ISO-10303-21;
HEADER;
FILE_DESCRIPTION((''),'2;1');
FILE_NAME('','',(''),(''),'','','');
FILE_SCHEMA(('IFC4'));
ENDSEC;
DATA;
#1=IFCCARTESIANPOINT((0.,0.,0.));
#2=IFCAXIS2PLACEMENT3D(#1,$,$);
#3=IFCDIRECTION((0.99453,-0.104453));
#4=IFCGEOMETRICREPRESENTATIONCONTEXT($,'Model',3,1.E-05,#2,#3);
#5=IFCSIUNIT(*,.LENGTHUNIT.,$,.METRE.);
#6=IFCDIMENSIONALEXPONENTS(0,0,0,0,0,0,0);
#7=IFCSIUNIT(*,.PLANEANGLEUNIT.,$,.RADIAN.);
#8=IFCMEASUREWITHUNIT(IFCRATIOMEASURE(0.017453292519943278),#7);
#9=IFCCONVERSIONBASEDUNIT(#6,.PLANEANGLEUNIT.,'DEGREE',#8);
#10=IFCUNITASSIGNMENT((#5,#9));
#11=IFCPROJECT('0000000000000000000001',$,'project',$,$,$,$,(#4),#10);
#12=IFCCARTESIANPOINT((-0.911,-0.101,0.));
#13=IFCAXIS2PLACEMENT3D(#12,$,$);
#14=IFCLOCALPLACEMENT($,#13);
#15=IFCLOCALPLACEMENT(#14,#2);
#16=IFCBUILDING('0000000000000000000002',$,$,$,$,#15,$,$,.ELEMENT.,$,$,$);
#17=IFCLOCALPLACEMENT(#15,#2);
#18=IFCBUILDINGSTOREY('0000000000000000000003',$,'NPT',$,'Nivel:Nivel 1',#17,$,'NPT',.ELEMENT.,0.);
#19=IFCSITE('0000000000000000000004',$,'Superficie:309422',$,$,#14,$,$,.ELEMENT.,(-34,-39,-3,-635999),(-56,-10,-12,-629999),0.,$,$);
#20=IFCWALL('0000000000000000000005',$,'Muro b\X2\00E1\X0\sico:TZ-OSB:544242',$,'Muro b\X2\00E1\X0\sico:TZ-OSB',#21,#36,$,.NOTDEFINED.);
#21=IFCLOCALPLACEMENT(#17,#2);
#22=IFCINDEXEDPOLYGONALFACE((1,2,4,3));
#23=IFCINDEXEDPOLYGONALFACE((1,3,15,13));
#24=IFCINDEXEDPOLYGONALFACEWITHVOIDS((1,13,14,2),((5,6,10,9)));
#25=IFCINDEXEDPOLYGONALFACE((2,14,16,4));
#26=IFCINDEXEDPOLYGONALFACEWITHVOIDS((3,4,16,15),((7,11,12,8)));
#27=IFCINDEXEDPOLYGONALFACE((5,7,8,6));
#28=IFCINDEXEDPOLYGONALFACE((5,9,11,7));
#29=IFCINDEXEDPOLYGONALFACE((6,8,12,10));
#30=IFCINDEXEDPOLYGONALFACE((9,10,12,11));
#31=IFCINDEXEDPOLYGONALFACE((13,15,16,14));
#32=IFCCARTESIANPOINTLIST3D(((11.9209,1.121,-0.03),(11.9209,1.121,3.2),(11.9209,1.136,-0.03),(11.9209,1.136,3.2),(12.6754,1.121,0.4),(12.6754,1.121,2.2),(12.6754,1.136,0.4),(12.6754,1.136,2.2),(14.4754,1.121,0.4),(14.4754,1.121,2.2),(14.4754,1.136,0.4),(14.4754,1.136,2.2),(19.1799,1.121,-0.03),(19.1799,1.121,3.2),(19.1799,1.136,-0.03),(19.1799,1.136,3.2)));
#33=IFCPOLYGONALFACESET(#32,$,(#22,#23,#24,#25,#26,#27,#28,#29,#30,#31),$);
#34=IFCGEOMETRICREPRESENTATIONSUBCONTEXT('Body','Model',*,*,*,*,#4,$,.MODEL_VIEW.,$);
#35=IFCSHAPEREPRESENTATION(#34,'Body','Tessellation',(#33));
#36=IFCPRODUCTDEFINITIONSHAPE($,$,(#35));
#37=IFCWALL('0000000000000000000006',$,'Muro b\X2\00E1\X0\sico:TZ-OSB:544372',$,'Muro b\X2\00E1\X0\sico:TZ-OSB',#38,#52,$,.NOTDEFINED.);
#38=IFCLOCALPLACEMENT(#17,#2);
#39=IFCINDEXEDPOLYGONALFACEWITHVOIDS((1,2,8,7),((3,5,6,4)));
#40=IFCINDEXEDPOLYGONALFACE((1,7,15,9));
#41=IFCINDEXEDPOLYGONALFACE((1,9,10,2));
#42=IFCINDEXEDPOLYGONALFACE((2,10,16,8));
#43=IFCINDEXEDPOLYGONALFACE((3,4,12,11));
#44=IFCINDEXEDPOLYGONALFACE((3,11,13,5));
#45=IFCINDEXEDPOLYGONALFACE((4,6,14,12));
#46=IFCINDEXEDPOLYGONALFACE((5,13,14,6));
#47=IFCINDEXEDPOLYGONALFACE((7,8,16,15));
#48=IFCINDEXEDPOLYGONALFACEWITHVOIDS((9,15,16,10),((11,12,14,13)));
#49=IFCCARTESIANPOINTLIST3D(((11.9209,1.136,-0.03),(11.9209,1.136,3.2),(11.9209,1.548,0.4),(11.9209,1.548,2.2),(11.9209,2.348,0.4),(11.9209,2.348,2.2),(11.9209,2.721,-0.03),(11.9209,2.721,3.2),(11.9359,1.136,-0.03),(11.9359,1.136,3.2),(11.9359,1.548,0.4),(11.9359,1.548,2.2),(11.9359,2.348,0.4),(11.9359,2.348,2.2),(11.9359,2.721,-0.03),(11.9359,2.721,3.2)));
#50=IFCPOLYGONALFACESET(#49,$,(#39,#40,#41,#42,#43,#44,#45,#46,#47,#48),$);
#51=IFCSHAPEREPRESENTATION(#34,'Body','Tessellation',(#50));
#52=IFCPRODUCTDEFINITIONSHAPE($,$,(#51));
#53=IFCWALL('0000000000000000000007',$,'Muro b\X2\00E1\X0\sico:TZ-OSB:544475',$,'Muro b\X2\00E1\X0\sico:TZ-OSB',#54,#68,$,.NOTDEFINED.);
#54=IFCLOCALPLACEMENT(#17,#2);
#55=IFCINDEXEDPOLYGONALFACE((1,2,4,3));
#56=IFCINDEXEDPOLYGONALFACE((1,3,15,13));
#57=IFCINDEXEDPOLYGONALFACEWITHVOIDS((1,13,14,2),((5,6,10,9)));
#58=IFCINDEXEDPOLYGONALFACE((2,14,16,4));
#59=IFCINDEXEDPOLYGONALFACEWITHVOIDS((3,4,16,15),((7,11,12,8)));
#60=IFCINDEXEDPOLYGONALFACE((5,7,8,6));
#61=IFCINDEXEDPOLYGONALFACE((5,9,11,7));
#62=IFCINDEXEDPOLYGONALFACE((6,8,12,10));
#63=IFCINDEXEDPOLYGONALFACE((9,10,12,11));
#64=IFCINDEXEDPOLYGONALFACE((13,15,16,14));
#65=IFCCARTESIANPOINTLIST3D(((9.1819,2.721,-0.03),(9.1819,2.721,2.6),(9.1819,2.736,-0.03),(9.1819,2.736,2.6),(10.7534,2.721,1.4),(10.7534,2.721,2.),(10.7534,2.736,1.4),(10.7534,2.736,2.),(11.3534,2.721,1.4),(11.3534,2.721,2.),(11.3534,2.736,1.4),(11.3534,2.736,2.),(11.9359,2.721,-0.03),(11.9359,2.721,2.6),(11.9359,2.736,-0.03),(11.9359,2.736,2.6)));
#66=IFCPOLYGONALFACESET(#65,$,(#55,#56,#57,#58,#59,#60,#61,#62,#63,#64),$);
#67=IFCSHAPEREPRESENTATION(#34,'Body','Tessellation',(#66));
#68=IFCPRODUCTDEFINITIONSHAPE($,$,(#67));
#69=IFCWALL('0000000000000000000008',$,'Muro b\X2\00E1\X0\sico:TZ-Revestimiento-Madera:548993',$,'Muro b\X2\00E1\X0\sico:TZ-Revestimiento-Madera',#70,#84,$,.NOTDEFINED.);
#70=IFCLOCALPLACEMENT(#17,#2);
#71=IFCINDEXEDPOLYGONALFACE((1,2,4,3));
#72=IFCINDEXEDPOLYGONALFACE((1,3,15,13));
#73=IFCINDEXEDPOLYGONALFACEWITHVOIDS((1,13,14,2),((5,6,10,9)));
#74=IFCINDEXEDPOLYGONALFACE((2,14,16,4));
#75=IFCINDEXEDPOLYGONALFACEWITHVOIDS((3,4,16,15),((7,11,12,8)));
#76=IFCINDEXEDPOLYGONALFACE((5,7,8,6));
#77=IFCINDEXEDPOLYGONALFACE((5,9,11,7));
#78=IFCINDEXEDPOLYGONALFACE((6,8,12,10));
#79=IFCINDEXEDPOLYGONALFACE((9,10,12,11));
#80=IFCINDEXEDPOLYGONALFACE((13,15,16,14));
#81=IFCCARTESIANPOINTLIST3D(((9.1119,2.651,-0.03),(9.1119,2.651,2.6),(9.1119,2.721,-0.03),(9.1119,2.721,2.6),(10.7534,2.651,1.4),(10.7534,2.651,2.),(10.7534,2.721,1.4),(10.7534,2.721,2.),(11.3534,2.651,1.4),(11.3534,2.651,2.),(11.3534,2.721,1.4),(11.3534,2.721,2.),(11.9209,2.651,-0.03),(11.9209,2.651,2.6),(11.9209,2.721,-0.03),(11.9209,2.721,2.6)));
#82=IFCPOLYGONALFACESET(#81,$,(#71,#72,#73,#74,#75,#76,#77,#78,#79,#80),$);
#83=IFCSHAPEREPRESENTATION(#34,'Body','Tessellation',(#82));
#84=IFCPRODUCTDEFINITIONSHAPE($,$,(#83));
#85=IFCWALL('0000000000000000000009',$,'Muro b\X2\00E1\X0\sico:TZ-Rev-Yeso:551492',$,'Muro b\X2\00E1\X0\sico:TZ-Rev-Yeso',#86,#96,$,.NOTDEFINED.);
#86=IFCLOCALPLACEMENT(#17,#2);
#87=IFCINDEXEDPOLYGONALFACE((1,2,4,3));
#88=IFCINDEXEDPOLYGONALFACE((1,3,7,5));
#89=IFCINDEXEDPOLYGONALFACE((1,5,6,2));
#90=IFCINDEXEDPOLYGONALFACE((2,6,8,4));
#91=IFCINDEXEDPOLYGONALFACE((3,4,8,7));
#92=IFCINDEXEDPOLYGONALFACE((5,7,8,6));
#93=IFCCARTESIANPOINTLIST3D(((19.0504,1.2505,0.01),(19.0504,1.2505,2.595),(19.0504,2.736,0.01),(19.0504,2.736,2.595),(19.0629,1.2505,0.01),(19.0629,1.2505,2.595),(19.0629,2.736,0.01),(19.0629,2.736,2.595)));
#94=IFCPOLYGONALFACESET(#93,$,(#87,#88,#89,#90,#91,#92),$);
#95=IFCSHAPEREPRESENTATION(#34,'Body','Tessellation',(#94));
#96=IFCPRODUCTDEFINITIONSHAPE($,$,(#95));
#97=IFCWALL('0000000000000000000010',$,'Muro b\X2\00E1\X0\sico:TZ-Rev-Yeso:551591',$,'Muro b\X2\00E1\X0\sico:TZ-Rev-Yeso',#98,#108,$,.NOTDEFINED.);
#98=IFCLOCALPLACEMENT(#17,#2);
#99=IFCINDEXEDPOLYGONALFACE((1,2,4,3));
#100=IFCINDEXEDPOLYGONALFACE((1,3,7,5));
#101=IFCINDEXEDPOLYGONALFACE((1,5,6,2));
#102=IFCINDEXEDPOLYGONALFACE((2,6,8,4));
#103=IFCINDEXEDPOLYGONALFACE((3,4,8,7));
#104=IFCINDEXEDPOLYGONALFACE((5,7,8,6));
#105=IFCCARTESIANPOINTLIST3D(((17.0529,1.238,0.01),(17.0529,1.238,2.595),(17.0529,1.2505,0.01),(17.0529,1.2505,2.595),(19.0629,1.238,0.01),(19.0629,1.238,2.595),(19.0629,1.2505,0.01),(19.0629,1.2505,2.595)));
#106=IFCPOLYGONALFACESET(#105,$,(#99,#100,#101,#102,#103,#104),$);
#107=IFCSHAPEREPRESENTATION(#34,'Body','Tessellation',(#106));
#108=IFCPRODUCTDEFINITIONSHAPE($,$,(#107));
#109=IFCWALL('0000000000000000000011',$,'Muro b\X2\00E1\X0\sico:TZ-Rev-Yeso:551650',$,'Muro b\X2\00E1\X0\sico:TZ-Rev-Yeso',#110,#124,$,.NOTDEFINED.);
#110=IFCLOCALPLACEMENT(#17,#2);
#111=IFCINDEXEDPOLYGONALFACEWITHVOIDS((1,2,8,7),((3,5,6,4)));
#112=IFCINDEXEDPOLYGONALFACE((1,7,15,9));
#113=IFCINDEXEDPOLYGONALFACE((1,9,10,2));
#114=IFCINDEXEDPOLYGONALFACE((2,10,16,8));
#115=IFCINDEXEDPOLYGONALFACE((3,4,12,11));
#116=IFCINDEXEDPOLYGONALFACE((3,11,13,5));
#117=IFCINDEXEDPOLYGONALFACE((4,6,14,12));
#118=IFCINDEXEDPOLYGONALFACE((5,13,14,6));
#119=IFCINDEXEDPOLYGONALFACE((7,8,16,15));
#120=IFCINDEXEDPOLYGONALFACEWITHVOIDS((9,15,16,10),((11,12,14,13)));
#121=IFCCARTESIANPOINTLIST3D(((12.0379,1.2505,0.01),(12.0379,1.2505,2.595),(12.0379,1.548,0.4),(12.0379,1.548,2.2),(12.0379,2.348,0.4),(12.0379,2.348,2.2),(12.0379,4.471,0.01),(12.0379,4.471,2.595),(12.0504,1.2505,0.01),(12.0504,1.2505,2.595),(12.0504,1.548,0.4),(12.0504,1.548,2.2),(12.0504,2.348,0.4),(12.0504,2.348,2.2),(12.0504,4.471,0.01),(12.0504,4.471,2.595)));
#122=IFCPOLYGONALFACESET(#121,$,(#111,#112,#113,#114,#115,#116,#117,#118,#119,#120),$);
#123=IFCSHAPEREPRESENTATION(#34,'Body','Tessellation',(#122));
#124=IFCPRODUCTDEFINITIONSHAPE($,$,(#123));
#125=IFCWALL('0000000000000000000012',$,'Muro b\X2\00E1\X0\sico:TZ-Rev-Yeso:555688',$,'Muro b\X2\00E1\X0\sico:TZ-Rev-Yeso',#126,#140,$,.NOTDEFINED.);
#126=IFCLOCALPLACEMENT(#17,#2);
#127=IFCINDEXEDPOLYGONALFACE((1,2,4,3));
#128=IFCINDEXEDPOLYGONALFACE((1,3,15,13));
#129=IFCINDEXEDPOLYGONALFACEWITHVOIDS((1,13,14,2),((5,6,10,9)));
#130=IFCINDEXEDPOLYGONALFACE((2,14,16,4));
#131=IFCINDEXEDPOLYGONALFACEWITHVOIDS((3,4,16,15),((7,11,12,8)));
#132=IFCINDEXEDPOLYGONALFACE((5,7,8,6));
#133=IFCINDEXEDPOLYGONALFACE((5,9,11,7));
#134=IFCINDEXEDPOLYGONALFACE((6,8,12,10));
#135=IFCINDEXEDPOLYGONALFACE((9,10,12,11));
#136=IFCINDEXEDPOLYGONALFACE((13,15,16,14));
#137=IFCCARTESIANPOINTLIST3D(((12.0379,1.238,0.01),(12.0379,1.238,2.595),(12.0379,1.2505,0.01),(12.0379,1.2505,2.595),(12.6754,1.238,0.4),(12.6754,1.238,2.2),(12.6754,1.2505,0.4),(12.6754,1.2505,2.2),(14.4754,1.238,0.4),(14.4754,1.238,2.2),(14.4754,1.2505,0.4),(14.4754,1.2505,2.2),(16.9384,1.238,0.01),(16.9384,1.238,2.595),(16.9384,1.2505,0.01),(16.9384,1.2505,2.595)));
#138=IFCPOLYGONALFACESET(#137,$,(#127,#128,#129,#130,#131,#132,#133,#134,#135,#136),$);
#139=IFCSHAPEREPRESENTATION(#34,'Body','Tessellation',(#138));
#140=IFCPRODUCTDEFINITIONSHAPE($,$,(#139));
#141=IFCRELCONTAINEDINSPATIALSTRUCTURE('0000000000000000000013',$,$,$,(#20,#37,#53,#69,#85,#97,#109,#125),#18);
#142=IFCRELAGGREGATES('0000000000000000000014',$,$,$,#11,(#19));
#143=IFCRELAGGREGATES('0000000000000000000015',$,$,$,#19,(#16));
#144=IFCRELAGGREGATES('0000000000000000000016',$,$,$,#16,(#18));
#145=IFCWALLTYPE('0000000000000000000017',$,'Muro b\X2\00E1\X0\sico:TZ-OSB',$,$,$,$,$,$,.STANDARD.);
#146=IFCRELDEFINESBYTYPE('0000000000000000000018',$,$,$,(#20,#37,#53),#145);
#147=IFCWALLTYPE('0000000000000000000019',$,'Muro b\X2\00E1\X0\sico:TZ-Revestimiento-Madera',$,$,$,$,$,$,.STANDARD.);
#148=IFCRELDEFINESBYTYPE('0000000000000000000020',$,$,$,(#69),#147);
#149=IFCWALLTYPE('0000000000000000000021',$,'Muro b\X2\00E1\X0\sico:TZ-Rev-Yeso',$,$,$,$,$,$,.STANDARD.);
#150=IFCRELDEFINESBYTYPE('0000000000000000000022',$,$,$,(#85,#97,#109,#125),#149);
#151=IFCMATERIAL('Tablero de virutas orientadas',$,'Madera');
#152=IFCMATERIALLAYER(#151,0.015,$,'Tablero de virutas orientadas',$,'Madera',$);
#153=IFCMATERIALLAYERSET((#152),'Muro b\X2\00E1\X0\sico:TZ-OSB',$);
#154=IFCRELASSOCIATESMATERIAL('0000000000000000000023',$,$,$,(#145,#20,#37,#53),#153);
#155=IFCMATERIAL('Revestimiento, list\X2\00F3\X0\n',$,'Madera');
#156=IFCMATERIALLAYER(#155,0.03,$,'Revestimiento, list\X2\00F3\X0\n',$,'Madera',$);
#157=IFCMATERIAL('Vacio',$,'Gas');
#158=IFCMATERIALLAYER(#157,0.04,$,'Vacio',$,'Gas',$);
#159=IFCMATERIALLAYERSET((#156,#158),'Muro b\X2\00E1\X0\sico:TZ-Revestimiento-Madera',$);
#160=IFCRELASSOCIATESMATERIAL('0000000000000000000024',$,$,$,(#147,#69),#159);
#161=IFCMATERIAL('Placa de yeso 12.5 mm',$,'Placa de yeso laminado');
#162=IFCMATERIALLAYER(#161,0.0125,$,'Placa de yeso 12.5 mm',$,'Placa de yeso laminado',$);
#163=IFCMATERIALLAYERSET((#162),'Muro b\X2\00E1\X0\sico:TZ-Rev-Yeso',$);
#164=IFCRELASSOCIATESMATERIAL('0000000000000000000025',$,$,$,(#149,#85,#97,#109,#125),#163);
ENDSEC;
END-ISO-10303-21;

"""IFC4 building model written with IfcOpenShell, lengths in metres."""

from ifc_helpers import new_model, entity, si_unit, converted_unit, direction, frame, frame_2d, origin, place, context, subcontext, project, spatial, rectangle, extrude, material, layer, layer_set, layer_usage, type_object, element, save


model = new_model("IFC4")

# Units and contexts
model_context = context("Model", 3, precision=1e-05, world=origin(), true_north=direction((0.99453, -0.104453)))
body_context = subcontext(model_context, "Body", "Model", "MODEL_VIEW")
ifc_project = project(units=[si_unit("LENGTHUNIT", "METRE"), converted_unit("PLANEANGLEUNIT", "DEGREE", entity("IfcRatioMeasure", 0.017453292519943278), si_unit("PLANEANGLEUNIT", "RADIAN"), dimensions=[0, 0, 0, 0, 0, 0, 0])], contexts=[model_context])

# Site, building, storey
site_placement = place(None, frame((-0.911, -0.101, 0.0)))
site = spatial("IfcSite", under=ifc_project, at=site_placement, Name="Superficie:309422", CompositionType="ELEMENT", RefLatitude=(-34, -39, -3, -635999), RefLongitude=(-56, -10, -12, -629999), RefElevation=0.0)
building_placement = place(site_placement, origin())
building = spatial("IfcBuilding", under=site, at=building_placement, CompositionType="ELEMENT")
storey_placement = place(building_placement, origin())
storey = spatial("IfcBuildingStorey", under=building, at=storey_placement, Name="NPT", ObjectType="Nivel:Nivel 1", LongName="NPT", CompositionType="ELEMENT", Elevation=0.0)

# Walls, openings
ifc_material_1 = material(Name="Tablero de virutas orientadas", Category="Madera")
ifc_layer_1 = layer(ifc_material_1, 0.015, Name="Tablero de virutas orientadas", Category="Madera")
ifc_layer_set_1 = layer_set([ifc_layer_1], Name="Muro básico:TZ-OSB")
ifc_layer_usage_1 = layer_usage(ifc_layer_set_1, "AXIS2", "NEGATIVE", 0.0075)
wall_type_1 = type_object("IfcWallType", Name="Muro básico:TZ-OSB", PredefinedType="STANDARD", material=ifc_layer_set_1)
wall_1_placement = place(storey_placement, frame((19.1799, 1.1285, -0.03), z_axis=(0.0, 0.0, 1.0), x_axis=(-1.0, 0.0, 0.0)))
wall_1 = element("IfcWall", 1, at=wall_1_placement, inside=storey, type_object=wall_type_1, material=ifc_layer_usage_1, Name="Muro básico:TZ-OSB:544242", ObjectType="Muro básico:TZ-OSB", PredefinedType="NOTDEFINED", context=body_context, shape_type="SweptSolid", body=[
    extrude(rectangle(XDim=7.259, YDim=0.015, at=frame_2d((3.6295, 0.0), x_axis=(-1.0, 0.0))), origin(), (0.0, 0.0, 1.0), 3.23),
])
opening_1_placement = place(wall_1_placement, frame((6.5045, 1.4145, 0.43)))
element("IfcOpeningElement", 2, at=opening_1_placement, cuts=wall_1, PredefinedType="OPENING", context=body_context, shape_type="SweptSolid", body=[
    extrude(rectangle(XDim=1.8, YDim=1.8, at=frame_2d((0.0, 0.0), x_axis=(0.0, 1.0))), frame((-0.9, -3.048, 0.9), z_axis=(0.0, 1.0, 0.0), x_axis=(-1.0, 0.0, 0.0)), (0.0, 0.0, 1.0), 3.048),
])
ifc_layer_usage_2 = layer_usage(ifc_layer_set_1, "AXIS2", "NEGATIVE", 0.0075)
wall_2_placement = place(storey_placement, frame((11.9284, 1.136, -0.03), z_axis=(0.0, 0.0, 1.0), x_axis=(0.0, 1.0, 0.0)))
wall_2 = element("IfcWall", 3, at=wall_2_placement, inside=storey, type_object=wall_type_1, material=ifc_layer_usage_2, Name="Muro básico:TZ-OSB:544372", ObjectType="Muro básico:TZ-OSB", PredefinedType="NOTDEFINED", context=body_context, shape_type="SweptSolid", body=[
    extrude(rectangle(XDim=1.585, YDim=0.015, at=frame_2d((0.7925, 0.0), x_axis=(-1.0, 0.0))), origin(), (0.0, 0.0, 1.0), 3.23),
])
opening_2_placement = place(wall_2_placement, frame((0.412, 1.4145, 0.43)))
element("IfcOpeningElement", 4, at=opening_2_placement, cuts=wall_2, PredefinedType="OPENING", context=body_context, shape_type="SweptSolid", body=[
    extrude(rectangle(XDim=1.8, YDim=0.8, at=frame_2d((0.0, 0.0), x_axis=(0.0, 1.0))), frame((0.4, -3.048, 0.9), z_axis=(0.0, 1.0, 0.0), x_axis=(-1.0, 0.0, 0.0)), (0.0, 0.0, 1.0), 3.048),
])
ifc_layer_usage_3 = layer_usage(ifc_layer_set_1, "AXIS2", "NEGATIVE", 0.0075)
wall_3_placement = place(storey_placement, frame((11.9359, 2.7285, -0.03), z_axis=(0.0, 0.0, 1.0), x_axis=(-1.0, 0.0, 0.0)))
wall_3 = element("IfcWall", 5, at=wall_3_placement, inside=storey, type_object=wall_type_1, material=ifc_layer_usage_3, Name="Muro básico:TZ-OSB:544475", ObjectType="Muro básico:TZ-OSB", PredefinedType="NOTDEFINED", context=body_context, shape_type="SweptSolid", body=[
    extrude(rectangle(XDim=2.754, YDim=0.015, at=frame_2d((1.377, 0.0), x_axis=(-1.0, 0.0))), origin(), (0.0, 0.0, 1.0), 2.63),
])
opening_3_placement = place(wall_3_placement, frame((1.1825, 1.4145, 1.43)))
element("IfcOpeningElement", 6, at=opening_3_placement, cuts=wall_3, PredefinedType="OPENING", context=body_context, shape_type="SweptSolid", body=[
    extrude(rectangle(XDim=0.6, YDim=0.6, at=frame_2d((0.0, 0.0), x_axis=(0.0, 1.0))), frame((-0.3, -3.048, 0.3), z_axis=(0.0, 1.0, 0.0), x_axis=(-1.0, 0.0, 0.0)), (0.0, 0.0, 1.0), 3.048),
])
ifc_material_2 = material(Name="Revestimiento, listón", Category="Madera")
ifc_layer_2 = layer(ifc_material_2, 0.03, Name="Revestimiento, listón", Category="Madera")
ifc_material_3 = material(Name="Vacio", Category="Gas")
ifc_layer_3 = layer(ifc_material_3, 0.04, Name="Vacio", Category="Gas")
ifc_layer_set_2 = layer_set([ifc_layer_2, ifc_layer_3], Name="Muro básico:TZ-Revestimiento-Madera")
ifc_layer_usage_4 = layer_usage(ifc_layer_set_2, "AXIS2", "NEGATIVE", 0.035)
wall_type_2 = type_object("IfcWallType", Name="Muro básico:TZ-Revestimiento-Madera", PredefinedType="STANDARD", material=ifc_layer_set_2)
wall_4_placement = place(storey_placement, frame((11.9209, 2.686, -0.03), z_axis=(0.0, 0.0, 1.0), x_axis=(-1.0, 0.0, 0.0)))
wall_4 = element("IfcWall", 7, at=wall_4_placement, inside=storey, type_object=wall_type_2, material=ifc_layer_usage_4, Name="Muro básico:TZ-Revestimiento-Madera:548993", ObjectType="Muro básico:TZ-Revestimiento-Madera", PredefinedType="NOTDEFINED", context=body_context, shape_type="SweptSolid", body=[
    extrude(rectangle(XDim=2.809, YDim=0.07, at=frame_2d((1.4045, 0.0), x_axis=(1.0, 0.0))), origin(), (0.0, 0.0, 1.0), 2.63),
])
opening_4_placement = place(wall_4_placement, frame((1.1675, 1.372, 1.43)))
element("IfcOpeningElement", 8, at=opening_4_placement, cuts=wall_4, PredefinedType="OPENING", context=body_context, shape_type="SweptSolid", body=[
    extrude(rectangle(XDim=0.6, YDim=0.6, at=frame_2d((0.0, 0.0), x_axis=(0.0, 1.0))), frame((-0.3, -3.048, 0.3), z_axis=(0.0, 1.0, 0.0), x_axis=(-1.0, 0.0, 0.0)), (0.0, 0.0, 1.0), 3.048),
])

# Walls
ifc_material_4 = material(Name="Placa de yeso 12.5 mm", Category="Placa de yeso laminado")
ifc_layer_4 = layer(ifc_material_4, 0.0125, Name="Placa de yeso 12.5 mm", Category="Placa de yeso laminado")
ifc_layer_set_3 = layer_set([ifc_layer_4], Name="Muro básico:TZ-Rev-Yeso")
ifc_layer_usage_5 = layer_usage(ifc_layer_set_3, "AXIS2", "NEGATIVE", 0.0063)
wall_type_3 = type_object("IfcWallType", Name="Muro básico:TZ-Rev-Yeso", PredefinedType="STANDARD", material=ifc_layer_set_3)
wall_5_placement = place(storey_placement, frame((19.0567, 2.736, 0.01), z_axis=(0.0, 0.0, 1.0), x_axis=(0.0, -1.0, 0.0)))
element("IfcWall", 9, at=wall_5_placement, inside=storey, type_object=wall_type_3, material=ifc_layer_usage_5, Name="Muro básico:TZ-Rev-Yeso:551492", ObjectType="Muro básico:TZ-Rev-Yeso", PredefinedType="NOTDEFINED", context=body_context, shape_type="SweptSolid", body=[
    extrude(rectangle(XDim=1.4855, YDim=0.0125, at=frame_2d((0.7428, 0.0), x_axis=(-1.0, 0.0))), origin(), (0.0, 0.0, 1.0), 2.585),
])
ifc_layer_usage_6 = layer_usage(ifc_layer_set_3, "AXIS2", "NEGATIVE", 0.0063)
wall_6_placement = place(storey_placement, frame((19.0629, 1.2443, 0.01), z_axis=(0.0, 0.0, 1.0), x_axis=(-1.0, 0.0, 0.0)))
element("IfcWall", 10, at=wall_6_placement, inside=storey, type_object=wall_type_3, material=ifc_layer_usage_6, Name="Muro básico:TZ-Rev-Yeso:551591", ObjectType="Muro básico:TZ-Rev-Yeso", PredefinedType="NOTDEFINED", context=body_context, shape_type="SweptSolid", body=[
    extrude(rectangle(XDim=2.01, YDim=0.0125, at=frame_2d((1.005, 0.0), x_axis=(-1.0, 0.0))), origin(), (0.0, 0.0, 1.0), 2.585),
])

# Walls, openings
ifc_layer_usage_7 = layer_usage(ifc_layer_set_3, "AXIS2", "NEGATIVE", 0.0063)
wall_7_placement = place(storey_placement, frame((12.0442, 1.2505, 0.01), z_axis=(0.0, 0.0, 1.0), x_axis=(0.0, 1.0, 0.0)))
wall_7 = element("IfcWall", 11, at=wall_7_placement, inside=storey, type_object=wall_type_3, material=ifc_layer_usage_7, Name="Muro básico:TZ-Rev-Yeso:551650", ObjectType="Muro básico:TZ-Rev-Yeso", PredefinedType="NOTDEFINED", context=body_context, shape_type="SweptSolid", body=[
    extrude(rectangle(XDim=3.2205, YDim=0.0125, at=frame_2d((1.6102, 0.0), x_axis=(-1.0, 0.0))), origin(), (0.0, 0.0, 1.0), 2.585),
])
opening_5_placement = place(wall_7_placement, frame((0.2975, 1.5303, 0.39)))
element("IfcOpeningElement", 12, at=opening_5_placement, cuts=wall_7, PredefinedType="OPENING", context=body_context, shape_type="SweptSolid", body=[
    extrude(rectangle(XDim=1.8, YDim=0.8, at=frame_2d((0.0, 0.0), x_axis=(0.0, 1.0))), frame((0.4, -3.048, 0.9), z_axis=(0.0, 1.0, 0.0), x_axis=(-1.0, 0.0, 0.0)), (0.0, 0.0, 1.0), 3.048),
])
ifc_layer_usage_8 = layer_usage(ifc_layer_set_3, "AXIS2", "NEGATIVE", 0.0063)
wall_8_placement = place(storey_placement, frame((16.9384, 1.2443, 0.01), z_axis=(0.0, 0.0, 1.0), x_axis=(-1.0, 0.0, 0.0)))
wall_8 = element("IfcWall", 13, at=wall_8_placement, inside=storey, type_object=wall_type_3, material=ifc_layer_usage_8, Name="Muro básico:TZ-Rev-Yeso:555688", ObjectType="Muro básico:TZ-Rev-Yeso", PredefinedType="NOTDEFINED", context=body_context, shape_type="SweptSolid", body=[
    extrude(rectangle(XDim=4.9005, YDim=0.0125, at=frame_2d((2.4503, 0.0), x_axis=(-1.0, 0.0))), origin(), (0.0, 0.0, 1.0), 2.585),
])
opening_6_placement = place(wall_8_placement, frame((4.263, 1.5303, 0.39)))
element("IfcOpeningElement", 14, at=opening_6_placement, cuts=wall_8, PredefinedType="OPENING", context=body_context, shape_type="SweptSolid", body=[
    extrude(rectangle(XDim=1.8, YDim=1.8, at=frame_2d((0.0, 0.0), x_axis=(0.0, 1.0))), frame((-0.9, -3.048, 0.9), z_axis=(0.0, 1.0, 0.0), x_axis=(-1.0, 0.0, 0.0)), (0.0, 0.0, 1.0), 3.048),
])

save(model, "model.ifc")
